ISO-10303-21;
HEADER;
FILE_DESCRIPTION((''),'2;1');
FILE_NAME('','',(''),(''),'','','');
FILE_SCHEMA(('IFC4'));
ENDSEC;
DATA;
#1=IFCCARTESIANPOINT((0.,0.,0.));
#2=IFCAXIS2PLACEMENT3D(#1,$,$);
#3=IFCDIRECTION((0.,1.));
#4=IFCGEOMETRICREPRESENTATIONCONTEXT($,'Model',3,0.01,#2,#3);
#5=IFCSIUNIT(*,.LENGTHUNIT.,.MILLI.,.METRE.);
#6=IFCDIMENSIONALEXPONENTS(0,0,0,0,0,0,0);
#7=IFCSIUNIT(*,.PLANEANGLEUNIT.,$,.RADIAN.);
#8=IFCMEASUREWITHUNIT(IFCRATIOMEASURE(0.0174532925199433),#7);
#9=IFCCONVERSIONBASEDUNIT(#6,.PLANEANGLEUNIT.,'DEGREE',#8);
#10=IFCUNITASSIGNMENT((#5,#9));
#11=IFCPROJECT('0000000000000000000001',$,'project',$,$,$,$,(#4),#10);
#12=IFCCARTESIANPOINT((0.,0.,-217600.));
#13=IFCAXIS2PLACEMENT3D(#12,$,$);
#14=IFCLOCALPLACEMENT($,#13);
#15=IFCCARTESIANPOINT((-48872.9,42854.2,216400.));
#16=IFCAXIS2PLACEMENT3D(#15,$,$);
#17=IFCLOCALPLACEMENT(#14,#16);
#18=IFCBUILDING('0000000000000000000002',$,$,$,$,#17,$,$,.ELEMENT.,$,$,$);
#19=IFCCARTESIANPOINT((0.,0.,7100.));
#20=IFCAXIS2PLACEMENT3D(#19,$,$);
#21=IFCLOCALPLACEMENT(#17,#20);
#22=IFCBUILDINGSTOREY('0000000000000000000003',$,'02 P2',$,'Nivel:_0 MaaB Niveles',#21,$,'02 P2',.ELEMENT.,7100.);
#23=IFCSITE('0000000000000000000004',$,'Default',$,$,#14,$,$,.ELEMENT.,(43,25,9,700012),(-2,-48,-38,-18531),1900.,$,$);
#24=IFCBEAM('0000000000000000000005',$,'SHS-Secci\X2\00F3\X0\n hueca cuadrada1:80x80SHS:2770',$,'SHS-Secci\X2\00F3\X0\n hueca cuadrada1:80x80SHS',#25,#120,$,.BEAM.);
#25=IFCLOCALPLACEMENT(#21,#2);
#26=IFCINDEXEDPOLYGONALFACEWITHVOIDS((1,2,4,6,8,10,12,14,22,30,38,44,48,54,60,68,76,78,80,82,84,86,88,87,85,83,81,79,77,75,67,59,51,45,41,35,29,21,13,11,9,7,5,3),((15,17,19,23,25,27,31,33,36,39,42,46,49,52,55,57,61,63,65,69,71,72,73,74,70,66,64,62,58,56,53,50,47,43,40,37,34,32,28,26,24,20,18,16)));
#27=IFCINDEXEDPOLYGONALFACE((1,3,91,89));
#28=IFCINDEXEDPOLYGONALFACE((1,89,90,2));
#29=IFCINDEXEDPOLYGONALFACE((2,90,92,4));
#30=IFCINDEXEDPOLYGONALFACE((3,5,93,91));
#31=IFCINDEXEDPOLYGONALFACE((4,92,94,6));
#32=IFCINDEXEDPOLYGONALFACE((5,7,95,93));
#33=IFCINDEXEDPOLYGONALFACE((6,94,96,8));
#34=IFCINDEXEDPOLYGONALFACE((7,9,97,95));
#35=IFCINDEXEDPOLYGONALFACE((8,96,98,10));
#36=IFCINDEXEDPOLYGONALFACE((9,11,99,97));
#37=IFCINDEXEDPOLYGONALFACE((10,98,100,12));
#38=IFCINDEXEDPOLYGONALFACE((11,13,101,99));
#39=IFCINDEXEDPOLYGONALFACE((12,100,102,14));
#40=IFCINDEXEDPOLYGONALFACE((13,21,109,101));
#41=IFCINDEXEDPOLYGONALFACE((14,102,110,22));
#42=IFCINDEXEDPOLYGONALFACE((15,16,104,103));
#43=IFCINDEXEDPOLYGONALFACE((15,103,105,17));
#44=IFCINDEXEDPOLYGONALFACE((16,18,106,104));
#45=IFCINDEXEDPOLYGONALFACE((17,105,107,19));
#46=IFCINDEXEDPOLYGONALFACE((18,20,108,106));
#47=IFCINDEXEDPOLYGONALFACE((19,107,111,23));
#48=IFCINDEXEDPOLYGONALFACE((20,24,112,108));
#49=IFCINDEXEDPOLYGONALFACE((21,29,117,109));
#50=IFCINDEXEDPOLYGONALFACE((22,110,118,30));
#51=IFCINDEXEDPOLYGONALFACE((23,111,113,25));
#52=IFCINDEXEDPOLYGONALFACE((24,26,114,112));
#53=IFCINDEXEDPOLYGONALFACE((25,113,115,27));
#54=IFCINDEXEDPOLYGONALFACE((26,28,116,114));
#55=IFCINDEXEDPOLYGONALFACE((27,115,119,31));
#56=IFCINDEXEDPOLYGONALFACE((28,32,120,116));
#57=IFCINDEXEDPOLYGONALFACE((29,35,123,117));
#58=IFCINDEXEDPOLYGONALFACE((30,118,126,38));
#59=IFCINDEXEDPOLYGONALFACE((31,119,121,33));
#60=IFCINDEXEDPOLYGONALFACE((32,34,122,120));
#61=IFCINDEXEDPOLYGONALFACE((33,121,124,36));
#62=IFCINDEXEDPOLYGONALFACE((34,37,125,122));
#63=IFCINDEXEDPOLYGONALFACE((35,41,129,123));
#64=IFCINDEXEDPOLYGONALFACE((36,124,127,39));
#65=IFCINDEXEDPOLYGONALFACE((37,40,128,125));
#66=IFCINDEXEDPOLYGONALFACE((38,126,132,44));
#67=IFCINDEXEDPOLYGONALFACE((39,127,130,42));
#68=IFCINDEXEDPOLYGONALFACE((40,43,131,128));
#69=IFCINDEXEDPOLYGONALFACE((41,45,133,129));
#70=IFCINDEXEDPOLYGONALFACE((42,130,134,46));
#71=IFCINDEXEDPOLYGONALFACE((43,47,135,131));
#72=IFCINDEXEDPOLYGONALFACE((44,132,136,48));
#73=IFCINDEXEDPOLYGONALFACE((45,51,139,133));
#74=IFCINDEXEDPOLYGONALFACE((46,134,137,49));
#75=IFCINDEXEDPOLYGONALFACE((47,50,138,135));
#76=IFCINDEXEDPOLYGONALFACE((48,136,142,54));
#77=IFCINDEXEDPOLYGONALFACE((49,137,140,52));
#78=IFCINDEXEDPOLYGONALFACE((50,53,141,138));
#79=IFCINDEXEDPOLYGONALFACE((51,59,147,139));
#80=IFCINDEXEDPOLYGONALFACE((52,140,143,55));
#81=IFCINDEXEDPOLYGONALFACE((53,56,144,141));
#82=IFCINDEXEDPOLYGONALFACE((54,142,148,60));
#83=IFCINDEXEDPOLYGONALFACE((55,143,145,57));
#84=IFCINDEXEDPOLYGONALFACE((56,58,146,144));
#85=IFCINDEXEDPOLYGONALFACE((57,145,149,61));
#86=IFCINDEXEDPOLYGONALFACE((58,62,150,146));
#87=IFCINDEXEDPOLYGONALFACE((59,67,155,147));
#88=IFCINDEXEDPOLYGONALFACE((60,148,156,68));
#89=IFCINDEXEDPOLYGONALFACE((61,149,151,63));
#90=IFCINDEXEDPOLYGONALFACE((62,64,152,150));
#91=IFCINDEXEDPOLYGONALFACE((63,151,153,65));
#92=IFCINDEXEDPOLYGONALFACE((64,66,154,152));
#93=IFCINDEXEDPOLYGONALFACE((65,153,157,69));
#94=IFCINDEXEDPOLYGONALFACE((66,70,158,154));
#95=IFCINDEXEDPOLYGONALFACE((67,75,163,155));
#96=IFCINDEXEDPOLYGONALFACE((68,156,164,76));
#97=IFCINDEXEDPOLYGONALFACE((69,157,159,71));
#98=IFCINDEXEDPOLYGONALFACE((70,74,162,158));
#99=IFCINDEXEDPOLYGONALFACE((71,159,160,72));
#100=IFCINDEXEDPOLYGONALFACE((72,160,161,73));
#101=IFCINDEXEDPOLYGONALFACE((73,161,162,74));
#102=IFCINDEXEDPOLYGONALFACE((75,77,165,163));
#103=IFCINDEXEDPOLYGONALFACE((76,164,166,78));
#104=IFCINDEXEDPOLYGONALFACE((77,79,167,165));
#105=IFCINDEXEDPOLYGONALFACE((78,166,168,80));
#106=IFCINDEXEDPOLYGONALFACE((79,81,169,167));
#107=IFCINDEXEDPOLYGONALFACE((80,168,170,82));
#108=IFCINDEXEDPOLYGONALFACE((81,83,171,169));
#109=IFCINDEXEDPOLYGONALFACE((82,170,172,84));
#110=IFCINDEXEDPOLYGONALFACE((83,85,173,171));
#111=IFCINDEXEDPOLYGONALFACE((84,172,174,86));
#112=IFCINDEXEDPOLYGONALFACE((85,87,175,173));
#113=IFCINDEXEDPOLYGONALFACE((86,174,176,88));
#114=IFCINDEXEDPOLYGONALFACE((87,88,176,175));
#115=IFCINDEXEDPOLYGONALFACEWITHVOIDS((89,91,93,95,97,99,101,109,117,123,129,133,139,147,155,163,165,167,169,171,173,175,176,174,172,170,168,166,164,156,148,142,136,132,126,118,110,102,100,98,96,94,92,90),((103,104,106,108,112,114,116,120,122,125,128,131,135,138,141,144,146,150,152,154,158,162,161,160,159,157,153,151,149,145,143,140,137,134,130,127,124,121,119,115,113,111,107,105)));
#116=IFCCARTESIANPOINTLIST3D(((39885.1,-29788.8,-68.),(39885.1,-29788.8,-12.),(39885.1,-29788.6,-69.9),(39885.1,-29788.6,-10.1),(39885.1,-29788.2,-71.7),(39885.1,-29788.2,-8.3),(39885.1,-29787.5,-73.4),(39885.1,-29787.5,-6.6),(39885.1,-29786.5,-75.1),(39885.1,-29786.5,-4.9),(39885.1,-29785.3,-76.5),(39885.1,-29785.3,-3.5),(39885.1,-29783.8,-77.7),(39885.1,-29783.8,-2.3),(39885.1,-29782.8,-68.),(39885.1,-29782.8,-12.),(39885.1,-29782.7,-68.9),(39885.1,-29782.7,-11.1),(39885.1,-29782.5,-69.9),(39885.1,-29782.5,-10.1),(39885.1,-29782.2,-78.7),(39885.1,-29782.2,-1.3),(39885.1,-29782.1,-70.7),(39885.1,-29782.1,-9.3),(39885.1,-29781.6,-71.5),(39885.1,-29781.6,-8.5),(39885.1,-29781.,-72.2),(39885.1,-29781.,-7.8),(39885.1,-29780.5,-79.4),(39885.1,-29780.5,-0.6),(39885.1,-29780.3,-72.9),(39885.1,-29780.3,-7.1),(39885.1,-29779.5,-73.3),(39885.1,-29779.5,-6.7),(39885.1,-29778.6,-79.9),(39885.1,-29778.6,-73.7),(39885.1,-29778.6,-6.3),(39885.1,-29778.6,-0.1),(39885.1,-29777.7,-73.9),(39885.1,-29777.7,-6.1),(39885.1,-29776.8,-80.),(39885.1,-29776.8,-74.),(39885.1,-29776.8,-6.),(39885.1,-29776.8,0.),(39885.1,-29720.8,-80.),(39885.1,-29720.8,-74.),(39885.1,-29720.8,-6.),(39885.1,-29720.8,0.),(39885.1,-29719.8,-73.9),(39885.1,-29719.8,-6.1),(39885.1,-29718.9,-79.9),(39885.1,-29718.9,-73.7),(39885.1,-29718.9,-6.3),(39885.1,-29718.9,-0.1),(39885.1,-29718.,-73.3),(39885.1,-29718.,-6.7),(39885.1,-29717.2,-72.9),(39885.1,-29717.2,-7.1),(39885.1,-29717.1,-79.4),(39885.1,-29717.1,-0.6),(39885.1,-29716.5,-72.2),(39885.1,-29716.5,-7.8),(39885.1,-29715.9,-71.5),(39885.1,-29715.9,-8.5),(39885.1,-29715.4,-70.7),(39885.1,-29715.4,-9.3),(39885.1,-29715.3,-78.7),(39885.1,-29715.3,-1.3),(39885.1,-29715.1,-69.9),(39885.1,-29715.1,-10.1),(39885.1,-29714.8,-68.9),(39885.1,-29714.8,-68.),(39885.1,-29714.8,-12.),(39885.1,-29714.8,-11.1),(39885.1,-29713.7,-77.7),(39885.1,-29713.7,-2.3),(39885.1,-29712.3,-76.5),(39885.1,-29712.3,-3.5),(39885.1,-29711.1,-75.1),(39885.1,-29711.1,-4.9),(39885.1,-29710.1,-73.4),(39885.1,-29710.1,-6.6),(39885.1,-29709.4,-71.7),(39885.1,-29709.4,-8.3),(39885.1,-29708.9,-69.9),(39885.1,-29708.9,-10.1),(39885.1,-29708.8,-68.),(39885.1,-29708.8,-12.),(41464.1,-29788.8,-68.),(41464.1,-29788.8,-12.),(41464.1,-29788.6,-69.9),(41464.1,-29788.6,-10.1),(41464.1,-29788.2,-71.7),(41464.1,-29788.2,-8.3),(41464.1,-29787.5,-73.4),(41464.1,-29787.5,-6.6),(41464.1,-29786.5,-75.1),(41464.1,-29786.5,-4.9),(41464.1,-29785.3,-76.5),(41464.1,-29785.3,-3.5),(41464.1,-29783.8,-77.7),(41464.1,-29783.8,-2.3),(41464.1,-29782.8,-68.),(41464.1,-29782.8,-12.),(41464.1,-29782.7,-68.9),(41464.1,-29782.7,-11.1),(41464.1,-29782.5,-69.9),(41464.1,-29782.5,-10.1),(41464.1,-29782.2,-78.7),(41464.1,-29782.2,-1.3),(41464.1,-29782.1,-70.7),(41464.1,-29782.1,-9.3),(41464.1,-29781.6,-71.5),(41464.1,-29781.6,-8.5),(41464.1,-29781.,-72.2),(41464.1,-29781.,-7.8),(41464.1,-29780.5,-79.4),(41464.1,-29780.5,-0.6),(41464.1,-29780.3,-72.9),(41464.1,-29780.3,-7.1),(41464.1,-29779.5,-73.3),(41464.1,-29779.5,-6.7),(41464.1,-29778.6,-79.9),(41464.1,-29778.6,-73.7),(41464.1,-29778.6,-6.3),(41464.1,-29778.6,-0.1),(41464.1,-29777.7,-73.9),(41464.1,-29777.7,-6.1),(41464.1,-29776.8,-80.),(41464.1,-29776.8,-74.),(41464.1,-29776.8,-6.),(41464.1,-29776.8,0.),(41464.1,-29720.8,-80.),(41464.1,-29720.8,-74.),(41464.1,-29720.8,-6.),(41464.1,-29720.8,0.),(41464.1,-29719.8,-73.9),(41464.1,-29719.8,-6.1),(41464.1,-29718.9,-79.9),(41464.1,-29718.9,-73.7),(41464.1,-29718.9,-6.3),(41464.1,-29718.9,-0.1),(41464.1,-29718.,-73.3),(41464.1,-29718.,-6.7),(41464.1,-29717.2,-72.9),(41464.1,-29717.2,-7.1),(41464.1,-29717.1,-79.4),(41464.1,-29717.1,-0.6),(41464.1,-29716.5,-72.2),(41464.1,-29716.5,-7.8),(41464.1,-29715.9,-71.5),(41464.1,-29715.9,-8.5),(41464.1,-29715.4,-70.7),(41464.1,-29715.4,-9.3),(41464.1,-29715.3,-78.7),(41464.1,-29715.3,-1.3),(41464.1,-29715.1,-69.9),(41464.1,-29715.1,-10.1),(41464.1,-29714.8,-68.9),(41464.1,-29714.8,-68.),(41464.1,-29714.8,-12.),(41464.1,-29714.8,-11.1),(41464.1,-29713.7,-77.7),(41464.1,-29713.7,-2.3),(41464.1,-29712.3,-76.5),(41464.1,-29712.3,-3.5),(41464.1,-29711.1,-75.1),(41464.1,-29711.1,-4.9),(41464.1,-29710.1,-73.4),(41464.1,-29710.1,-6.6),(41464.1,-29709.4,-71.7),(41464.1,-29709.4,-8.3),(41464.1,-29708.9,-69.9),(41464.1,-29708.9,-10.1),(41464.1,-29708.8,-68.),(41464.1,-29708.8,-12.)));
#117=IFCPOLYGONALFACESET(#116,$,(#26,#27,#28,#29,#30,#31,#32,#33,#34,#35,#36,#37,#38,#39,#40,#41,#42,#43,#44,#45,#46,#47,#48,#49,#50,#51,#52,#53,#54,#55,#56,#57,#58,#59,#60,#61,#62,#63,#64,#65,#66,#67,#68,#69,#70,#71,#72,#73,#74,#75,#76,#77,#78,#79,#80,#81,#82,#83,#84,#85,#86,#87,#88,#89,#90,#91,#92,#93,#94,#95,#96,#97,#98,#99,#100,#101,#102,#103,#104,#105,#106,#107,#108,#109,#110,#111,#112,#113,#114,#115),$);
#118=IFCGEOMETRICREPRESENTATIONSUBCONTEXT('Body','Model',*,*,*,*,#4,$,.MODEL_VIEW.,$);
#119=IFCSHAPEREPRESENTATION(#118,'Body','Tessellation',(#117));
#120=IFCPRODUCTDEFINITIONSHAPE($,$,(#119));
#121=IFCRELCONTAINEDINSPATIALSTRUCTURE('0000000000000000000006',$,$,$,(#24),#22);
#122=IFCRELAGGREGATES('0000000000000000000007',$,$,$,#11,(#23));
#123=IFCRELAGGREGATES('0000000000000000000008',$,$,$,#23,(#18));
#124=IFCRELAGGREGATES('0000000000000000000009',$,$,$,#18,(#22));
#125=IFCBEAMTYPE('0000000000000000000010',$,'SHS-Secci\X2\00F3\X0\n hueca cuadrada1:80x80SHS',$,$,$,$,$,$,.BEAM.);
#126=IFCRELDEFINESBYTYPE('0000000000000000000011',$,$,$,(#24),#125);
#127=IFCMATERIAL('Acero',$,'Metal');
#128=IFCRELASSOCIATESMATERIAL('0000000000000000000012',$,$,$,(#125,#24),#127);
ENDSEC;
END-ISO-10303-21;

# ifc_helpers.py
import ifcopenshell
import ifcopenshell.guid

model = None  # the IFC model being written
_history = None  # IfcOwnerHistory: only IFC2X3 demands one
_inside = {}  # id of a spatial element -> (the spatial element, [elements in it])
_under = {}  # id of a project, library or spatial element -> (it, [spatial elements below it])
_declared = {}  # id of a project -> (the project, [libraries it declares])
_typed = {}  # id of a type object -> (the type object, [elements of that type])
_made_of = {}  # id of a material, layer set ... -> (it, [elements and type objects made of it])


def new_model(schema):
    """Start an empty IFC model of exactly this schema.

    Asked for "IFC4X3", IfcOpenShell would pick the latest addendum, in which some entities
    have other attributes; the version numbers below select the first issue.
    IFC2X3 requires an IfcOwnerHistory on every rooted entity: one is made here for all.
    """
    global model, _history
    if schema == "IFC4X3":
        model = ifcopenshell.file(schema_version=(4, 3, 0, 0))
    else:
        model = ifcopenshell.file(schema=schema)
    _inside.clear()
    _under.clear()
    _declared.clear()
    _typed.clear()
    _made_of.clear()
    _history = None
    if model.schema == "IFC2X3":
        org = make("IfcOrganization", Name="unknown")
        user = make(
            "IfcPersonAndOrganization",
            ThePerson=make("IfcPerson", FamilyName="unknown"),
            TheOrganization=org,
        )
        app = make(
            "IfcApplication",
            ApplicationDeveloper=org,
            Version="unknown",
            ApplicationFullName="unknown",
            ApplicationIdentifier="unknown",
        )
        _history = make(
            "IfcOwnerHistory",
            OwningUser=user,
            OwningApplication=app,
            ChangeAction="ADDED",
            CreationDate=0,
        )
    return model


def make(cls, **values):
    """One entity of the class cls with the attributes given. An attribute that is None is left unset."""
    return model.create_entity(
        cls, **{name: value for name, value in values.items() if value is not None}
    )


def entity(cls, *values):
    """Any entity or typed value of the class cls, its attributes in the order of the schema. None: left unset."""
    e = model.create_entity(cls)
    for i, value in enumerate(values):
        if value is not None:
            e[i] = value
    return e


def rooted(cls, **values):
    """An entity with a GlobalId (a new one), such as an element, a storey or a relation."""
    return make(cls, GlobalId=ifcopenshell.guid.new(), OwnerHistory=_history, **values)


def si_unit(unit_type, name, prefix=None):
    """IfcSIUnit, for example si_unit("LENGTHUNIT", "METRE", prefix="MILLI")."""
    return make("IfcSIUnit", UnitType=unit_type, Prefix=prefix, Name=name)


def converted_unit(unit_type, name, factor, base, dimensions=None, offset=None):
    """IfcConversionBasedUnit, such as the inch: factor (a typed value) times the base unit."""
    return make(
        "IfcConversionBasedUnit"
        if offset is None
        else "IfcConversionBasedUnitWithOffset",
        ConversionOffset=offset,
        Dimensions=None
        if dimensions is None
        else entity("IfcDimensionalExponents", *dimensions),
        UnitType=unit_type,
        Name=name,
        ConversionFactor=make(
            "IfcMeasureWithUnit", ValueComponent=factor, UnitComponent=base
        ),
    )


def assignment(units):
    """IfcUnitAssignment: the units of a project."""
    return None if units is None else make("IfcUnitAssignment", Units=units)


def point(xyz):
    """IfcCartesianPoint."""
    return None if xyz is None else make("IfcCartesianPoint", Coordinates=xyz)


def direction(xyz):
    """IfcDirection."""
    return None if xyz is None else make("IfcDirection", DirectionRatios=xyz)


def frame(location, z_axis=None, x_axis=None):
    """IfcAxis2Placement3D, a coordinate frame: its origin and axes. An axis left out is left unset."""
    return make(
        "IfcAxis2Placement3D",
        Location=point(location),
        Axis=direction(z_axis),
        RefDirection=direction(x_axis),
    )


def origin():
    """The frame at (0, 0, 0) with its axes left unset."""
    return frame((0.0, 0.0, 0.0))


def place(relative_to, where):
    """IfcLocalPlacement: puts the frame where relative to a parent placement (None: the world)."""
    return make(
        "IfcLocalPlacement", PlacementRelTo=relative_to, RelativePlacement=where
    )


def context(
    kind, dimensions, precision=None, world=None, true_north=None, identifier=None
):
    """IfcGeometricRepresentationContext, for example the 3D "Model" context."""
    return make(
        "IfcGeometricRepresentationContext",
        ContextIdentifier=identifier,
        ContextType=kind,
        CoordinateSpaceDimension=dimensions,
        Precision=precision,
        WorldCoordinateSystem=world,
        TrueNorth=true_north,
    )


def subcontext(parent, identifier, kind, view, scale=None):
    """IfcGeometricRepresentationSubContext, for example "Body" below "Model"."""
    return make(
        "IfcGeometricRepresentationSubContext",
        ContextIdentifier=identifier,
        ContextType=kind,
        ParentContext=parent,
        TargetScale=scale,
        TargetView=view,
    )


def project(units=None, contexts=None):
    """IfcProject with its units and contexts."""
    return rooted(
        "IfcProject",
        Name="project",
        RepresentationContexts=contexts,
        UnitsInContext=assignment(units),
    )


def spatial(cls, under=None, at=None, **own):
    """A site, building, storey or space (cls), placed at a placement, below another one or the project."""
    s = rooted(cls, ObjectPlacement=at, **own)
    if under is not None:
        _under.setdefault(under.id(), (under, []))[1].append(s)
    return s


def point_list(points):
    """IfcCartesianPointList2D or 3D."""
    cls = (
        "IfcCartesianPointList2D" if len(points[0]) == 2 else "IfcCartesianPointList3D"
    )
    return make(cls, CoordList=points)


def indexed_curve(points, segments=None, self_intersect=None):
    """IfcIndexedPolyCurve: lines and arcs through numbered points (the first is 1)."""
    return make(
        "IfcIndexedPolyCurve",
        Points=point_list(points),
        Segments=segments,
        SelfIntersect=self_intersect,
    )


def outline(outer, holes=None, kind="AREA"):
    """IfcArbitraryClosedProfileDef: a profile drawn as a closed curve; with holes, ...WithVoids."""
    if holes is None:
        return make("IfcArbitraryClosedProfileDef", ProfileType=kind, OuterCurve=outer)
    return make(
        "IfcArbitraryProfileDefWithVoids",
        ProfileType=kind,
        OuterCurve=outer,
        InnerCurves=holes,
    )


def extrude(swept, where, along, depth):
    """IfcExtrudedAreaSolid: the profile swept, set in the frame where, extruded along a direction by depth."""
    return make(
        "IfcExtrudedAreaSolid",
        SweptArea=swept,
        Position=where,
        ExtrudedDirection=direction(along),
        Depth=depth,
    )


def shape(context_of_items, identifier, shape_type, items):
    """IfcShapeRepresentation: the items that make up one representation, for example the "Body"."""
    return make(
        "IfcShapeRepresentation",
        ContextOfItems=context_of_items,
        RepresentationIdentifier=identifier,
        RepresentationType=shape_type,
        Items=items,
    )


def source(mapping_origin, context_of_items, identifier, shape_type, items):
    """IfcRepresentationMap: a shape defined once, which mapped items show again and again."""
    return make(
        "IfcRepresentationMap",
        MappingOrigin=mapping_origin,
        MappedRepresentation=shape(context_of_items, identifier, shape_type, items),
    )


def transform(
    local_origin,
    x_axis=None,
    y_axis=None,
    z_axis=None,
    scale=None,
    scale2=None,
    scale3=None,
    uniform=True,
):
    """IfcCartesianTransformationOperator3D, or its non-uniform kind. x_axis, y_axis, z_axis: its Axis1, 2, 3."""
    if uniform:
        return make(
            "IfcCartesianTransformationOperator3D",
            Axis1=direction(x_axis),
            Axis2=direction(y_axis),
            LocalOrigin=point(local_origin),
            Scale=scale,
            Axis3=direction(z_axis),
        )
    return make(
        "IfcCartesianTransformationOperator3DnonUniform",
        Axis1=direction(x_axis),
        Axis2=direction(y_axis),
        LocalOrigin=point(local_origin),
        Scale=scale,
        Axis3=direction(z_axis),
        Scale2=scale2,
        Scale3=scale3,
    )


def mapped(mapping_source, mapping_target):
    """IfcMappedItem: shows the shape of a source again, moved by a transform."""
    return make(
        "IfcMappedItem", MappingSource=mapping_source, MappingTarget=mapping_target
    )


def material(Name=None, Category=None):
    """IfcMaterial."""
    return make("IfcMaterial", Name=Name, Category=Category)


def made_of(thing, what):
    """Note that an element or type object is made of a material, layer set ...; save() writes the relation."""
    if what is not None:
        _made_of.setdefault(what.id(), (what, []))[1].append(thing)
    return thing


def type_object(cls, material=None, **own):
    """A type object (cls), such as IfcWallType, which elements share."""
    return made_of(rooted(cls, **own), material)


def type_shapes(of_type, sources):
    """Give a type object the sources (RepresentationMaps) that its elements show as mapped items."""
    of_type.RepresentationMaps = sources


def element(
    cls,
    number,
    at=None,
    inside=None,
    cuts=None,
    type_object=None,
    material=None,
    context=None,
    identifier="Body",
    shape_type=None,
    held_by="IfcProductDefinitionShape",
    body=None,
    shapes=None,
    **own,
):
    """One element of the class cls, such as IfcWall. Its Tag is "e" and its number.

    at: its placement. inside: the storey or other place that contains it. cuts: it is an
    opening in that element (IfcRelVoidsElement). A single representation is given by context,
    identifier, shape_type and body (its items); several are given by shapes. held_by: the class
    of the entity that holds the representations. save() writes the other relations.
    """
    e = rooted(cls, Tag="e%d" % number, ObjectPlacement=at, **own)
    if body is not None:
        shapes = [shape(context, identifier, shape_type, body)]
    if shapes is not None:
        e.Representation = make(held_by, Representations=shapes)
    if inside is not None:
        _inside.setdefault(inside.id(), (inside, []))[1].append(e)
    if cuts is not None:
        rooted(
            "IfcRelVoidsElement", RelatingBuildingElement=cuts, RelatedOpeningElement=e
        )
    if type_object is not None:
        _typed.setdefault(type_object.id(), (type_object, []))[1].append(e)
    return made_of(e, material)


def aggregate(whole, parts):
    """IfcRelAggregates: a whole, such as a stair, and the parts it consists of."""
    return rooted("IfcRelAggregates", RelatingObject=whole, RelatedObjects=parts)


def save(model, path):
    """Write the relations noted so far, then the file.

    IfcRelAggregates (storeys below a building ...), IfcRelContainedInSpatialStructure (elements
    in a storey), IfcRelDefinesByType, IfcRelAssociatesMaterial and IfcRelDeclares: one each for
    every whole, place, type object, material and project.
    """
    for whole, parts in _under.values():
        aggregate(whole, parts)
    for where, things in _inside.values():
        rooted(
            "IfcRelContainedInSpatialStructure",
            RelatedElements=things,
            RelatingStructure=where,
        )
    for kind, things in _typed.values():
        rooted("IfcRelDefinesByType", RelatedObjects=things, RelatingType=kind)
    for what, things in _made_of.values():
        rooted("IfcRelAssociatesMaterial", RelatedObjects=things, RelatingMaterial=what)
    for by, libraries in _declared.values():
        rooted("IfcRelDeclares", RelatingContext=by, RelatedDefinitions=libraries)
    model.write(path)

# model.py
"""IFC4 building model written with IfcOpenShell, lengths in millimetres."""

from ifc_helpers import new_model, entity, si_unit, converted_unit, direction, frame, origin, place, context, subcontext, project, spatial, indexed_curve, outline, extrude, source, transform, mapped, material, type_object, type_shapes, element, save


model = new_model("IFC4")

# Units and contexts
model_context = context("Model", 3, precision=0.01, world=origin(), true_north=direction((0.0, 1.0)))
body_context = subcontext(model_context, "Body", "Model", "MODEL_VIEW")
ifc_project = project(units=[si_unit("LENGTHUNIT", "METRE", prefix="MILLI"), converted_unit("PLANEANGLEUNIT", "DEGREE", entity("IfcRatioMeasure", 0.0174532925199433), si_unit("PLANEANGLEUNIT", "RADIAN"), dimensions=[0, 0, 0, 0, 0, 0, 0])], contexts=[model_context])

# Site, building, storey
site_placement = place(None, frame((0.0, 0.0, -217600.0)))
site = spatial("IfcSite", under=ifc_project, at=site_placement, Name="Default", CompositionType="ELEMENT", RefLatitude=(43, 25, 9, 700012), RefLongitude=(-2, -48, -38, -18531), RefElevation=1900.0)
building_placement = place(site_placement, frame((-48872.9, 42854.2, 216400.0)))
building = spatial("IfcBuilding", under=site, at=building_placement, CompositionType="ELEMENT")
storey_placement = place(building_placement, frame((0.0, 0.0, 7100.0)))
storey = spatial("IfcBuildingStorey", under=building, at=storey_placement, Name="02 P2", ObjectType="Nivel:_0 MaaB Niveles", LongName="02 P2", CompositionType="ELEMENT", Elevation=7100.0)

# Shared definitions
ifc_material_1 = material(Name="Acero", Category="Metal")

# Beam
beam_type_1 = type_object("IfcBeamType", Name="SHS-Sección hueca cuadrada1:80x80SHS", PredefinedType="BEAM", material=ifc_material_1)
shared_shape_1 = source(origin(), body_context, "Body", "SweptSolid", [
    extrude(outline(indexed_curve([(-40.0, -28.0), (-39.9, -29.9), (-39.4, -31.7), (-38.7, -33.4), (-37.7, -35.1), (-36.5, -36.5), (-35.1, -37.7), (-33.4, -38.7), (-31.7, -39.4), (-29.9, -39.9), (-28.0, -40.0), (28.0, -40.0), (29.9, -39.9), (31.7, -39.4), (33.4, -38.7), (35.1, -37.7), (36.5, -36.5), (37.7, -35.1), (38.7, -33.4), (39.4, -31.7), (39.9, -29.9), (40.0, -28.0), (40.0, 28.0), (39.9, 29.9), (39.4, 31.7), (38.7, 33.4), (37.7, 35.1), (36.5, 36.5), (35.1, 37.7), (33.4, 38.7), (31.7, 39.4), (29.9, 39.9), (28.0, 40.0), (-28.0, 40.0), (-29.9, 39.9), (-31.7, 39.4), (-33.4, 38.7), (-35.1, 37.7), (-36.5, 36.5), (-37.7, 35.1), (-38.7, 33.4), (-39.4, 31.7), (-39.9, 29.9), (-40.0, 28.0), (-40.0, -28.0)], self_intersect=False), holes=[indexed_curve([(28.0, -34.0), (-28.0, -34.0), (-28.9, -33.9), (-29.9, -33.7), (-30.7, -33.3), (-31.5, -32.9), (-32.2, -32.2), (-32.9, -31.5), (-33.3, -30.7), (-33.7, -29.9), (-33.9, -28.9), (-34.0, -28.0), (-34.0, 28.0), (-33.9, 28.9), (-33.7, 29.9), (-33.3, 30.7), (-32.9, 31.5), (-32.2, 32.2), (-31.5, 32.9), (-30.7, 33.3), (-29.9, 33.7), (-28.9, 33.9), (-28.0, 34.0), (28.0, 34.0), (28.9, 33.9), (29.9, 33.7), (30.7, 33.3), (31.5, 32.9), (32.2, 32.2), (32.9, 31.5), (33.3, 30.7), (33.7, 29.9), (33.9, 28.9), (34.0, 28.0), (34.0, -28.0), (33.9, -28.9), (33.7, -29.9), (33.3, -30.7), (32.9, -31.5), (32.2, -32.2), (31.5, -32.9), (30.7, -33.3), (29.9, -33.7), (28.9, -33.9), (28.0, -34.0)], self_intersect=False)]), frame((-733.0, 0.0, 0.0), z_axis=(1.0, 0.0, 0.0), x_axis=(0.0, -1.0, 0.0)), (0.0, 0.0, 1.0), 1579.0),
])
type_shapes(beam_type_1, [shared_shape_1])
beam_1_placement = place(storey_placement, frame((40731.1, -29748.8, -40.0), z_axis=(0.0, 0.0, 1.0), x_axis=(-1.0, 0.0, 0.0)))
element("IfcBeam", 1, at=beam_1_placement, inside=storey, type_object=beam_type_1, material=ifc_material_1, Name="SHS-Sección hueca cuadrada1:80x80SHS:2770", ObjectType="SHS-Sección hueca cuadrada1:80x80SHS", PredefinedType="BEAM", context=body_context, shape_type="MappedRepresentation", body=[
    mapped(shared_shape_1, transform((0.0, 0.0, 0.0), scale=1.0)),
])

save(model, "model.ifc")
